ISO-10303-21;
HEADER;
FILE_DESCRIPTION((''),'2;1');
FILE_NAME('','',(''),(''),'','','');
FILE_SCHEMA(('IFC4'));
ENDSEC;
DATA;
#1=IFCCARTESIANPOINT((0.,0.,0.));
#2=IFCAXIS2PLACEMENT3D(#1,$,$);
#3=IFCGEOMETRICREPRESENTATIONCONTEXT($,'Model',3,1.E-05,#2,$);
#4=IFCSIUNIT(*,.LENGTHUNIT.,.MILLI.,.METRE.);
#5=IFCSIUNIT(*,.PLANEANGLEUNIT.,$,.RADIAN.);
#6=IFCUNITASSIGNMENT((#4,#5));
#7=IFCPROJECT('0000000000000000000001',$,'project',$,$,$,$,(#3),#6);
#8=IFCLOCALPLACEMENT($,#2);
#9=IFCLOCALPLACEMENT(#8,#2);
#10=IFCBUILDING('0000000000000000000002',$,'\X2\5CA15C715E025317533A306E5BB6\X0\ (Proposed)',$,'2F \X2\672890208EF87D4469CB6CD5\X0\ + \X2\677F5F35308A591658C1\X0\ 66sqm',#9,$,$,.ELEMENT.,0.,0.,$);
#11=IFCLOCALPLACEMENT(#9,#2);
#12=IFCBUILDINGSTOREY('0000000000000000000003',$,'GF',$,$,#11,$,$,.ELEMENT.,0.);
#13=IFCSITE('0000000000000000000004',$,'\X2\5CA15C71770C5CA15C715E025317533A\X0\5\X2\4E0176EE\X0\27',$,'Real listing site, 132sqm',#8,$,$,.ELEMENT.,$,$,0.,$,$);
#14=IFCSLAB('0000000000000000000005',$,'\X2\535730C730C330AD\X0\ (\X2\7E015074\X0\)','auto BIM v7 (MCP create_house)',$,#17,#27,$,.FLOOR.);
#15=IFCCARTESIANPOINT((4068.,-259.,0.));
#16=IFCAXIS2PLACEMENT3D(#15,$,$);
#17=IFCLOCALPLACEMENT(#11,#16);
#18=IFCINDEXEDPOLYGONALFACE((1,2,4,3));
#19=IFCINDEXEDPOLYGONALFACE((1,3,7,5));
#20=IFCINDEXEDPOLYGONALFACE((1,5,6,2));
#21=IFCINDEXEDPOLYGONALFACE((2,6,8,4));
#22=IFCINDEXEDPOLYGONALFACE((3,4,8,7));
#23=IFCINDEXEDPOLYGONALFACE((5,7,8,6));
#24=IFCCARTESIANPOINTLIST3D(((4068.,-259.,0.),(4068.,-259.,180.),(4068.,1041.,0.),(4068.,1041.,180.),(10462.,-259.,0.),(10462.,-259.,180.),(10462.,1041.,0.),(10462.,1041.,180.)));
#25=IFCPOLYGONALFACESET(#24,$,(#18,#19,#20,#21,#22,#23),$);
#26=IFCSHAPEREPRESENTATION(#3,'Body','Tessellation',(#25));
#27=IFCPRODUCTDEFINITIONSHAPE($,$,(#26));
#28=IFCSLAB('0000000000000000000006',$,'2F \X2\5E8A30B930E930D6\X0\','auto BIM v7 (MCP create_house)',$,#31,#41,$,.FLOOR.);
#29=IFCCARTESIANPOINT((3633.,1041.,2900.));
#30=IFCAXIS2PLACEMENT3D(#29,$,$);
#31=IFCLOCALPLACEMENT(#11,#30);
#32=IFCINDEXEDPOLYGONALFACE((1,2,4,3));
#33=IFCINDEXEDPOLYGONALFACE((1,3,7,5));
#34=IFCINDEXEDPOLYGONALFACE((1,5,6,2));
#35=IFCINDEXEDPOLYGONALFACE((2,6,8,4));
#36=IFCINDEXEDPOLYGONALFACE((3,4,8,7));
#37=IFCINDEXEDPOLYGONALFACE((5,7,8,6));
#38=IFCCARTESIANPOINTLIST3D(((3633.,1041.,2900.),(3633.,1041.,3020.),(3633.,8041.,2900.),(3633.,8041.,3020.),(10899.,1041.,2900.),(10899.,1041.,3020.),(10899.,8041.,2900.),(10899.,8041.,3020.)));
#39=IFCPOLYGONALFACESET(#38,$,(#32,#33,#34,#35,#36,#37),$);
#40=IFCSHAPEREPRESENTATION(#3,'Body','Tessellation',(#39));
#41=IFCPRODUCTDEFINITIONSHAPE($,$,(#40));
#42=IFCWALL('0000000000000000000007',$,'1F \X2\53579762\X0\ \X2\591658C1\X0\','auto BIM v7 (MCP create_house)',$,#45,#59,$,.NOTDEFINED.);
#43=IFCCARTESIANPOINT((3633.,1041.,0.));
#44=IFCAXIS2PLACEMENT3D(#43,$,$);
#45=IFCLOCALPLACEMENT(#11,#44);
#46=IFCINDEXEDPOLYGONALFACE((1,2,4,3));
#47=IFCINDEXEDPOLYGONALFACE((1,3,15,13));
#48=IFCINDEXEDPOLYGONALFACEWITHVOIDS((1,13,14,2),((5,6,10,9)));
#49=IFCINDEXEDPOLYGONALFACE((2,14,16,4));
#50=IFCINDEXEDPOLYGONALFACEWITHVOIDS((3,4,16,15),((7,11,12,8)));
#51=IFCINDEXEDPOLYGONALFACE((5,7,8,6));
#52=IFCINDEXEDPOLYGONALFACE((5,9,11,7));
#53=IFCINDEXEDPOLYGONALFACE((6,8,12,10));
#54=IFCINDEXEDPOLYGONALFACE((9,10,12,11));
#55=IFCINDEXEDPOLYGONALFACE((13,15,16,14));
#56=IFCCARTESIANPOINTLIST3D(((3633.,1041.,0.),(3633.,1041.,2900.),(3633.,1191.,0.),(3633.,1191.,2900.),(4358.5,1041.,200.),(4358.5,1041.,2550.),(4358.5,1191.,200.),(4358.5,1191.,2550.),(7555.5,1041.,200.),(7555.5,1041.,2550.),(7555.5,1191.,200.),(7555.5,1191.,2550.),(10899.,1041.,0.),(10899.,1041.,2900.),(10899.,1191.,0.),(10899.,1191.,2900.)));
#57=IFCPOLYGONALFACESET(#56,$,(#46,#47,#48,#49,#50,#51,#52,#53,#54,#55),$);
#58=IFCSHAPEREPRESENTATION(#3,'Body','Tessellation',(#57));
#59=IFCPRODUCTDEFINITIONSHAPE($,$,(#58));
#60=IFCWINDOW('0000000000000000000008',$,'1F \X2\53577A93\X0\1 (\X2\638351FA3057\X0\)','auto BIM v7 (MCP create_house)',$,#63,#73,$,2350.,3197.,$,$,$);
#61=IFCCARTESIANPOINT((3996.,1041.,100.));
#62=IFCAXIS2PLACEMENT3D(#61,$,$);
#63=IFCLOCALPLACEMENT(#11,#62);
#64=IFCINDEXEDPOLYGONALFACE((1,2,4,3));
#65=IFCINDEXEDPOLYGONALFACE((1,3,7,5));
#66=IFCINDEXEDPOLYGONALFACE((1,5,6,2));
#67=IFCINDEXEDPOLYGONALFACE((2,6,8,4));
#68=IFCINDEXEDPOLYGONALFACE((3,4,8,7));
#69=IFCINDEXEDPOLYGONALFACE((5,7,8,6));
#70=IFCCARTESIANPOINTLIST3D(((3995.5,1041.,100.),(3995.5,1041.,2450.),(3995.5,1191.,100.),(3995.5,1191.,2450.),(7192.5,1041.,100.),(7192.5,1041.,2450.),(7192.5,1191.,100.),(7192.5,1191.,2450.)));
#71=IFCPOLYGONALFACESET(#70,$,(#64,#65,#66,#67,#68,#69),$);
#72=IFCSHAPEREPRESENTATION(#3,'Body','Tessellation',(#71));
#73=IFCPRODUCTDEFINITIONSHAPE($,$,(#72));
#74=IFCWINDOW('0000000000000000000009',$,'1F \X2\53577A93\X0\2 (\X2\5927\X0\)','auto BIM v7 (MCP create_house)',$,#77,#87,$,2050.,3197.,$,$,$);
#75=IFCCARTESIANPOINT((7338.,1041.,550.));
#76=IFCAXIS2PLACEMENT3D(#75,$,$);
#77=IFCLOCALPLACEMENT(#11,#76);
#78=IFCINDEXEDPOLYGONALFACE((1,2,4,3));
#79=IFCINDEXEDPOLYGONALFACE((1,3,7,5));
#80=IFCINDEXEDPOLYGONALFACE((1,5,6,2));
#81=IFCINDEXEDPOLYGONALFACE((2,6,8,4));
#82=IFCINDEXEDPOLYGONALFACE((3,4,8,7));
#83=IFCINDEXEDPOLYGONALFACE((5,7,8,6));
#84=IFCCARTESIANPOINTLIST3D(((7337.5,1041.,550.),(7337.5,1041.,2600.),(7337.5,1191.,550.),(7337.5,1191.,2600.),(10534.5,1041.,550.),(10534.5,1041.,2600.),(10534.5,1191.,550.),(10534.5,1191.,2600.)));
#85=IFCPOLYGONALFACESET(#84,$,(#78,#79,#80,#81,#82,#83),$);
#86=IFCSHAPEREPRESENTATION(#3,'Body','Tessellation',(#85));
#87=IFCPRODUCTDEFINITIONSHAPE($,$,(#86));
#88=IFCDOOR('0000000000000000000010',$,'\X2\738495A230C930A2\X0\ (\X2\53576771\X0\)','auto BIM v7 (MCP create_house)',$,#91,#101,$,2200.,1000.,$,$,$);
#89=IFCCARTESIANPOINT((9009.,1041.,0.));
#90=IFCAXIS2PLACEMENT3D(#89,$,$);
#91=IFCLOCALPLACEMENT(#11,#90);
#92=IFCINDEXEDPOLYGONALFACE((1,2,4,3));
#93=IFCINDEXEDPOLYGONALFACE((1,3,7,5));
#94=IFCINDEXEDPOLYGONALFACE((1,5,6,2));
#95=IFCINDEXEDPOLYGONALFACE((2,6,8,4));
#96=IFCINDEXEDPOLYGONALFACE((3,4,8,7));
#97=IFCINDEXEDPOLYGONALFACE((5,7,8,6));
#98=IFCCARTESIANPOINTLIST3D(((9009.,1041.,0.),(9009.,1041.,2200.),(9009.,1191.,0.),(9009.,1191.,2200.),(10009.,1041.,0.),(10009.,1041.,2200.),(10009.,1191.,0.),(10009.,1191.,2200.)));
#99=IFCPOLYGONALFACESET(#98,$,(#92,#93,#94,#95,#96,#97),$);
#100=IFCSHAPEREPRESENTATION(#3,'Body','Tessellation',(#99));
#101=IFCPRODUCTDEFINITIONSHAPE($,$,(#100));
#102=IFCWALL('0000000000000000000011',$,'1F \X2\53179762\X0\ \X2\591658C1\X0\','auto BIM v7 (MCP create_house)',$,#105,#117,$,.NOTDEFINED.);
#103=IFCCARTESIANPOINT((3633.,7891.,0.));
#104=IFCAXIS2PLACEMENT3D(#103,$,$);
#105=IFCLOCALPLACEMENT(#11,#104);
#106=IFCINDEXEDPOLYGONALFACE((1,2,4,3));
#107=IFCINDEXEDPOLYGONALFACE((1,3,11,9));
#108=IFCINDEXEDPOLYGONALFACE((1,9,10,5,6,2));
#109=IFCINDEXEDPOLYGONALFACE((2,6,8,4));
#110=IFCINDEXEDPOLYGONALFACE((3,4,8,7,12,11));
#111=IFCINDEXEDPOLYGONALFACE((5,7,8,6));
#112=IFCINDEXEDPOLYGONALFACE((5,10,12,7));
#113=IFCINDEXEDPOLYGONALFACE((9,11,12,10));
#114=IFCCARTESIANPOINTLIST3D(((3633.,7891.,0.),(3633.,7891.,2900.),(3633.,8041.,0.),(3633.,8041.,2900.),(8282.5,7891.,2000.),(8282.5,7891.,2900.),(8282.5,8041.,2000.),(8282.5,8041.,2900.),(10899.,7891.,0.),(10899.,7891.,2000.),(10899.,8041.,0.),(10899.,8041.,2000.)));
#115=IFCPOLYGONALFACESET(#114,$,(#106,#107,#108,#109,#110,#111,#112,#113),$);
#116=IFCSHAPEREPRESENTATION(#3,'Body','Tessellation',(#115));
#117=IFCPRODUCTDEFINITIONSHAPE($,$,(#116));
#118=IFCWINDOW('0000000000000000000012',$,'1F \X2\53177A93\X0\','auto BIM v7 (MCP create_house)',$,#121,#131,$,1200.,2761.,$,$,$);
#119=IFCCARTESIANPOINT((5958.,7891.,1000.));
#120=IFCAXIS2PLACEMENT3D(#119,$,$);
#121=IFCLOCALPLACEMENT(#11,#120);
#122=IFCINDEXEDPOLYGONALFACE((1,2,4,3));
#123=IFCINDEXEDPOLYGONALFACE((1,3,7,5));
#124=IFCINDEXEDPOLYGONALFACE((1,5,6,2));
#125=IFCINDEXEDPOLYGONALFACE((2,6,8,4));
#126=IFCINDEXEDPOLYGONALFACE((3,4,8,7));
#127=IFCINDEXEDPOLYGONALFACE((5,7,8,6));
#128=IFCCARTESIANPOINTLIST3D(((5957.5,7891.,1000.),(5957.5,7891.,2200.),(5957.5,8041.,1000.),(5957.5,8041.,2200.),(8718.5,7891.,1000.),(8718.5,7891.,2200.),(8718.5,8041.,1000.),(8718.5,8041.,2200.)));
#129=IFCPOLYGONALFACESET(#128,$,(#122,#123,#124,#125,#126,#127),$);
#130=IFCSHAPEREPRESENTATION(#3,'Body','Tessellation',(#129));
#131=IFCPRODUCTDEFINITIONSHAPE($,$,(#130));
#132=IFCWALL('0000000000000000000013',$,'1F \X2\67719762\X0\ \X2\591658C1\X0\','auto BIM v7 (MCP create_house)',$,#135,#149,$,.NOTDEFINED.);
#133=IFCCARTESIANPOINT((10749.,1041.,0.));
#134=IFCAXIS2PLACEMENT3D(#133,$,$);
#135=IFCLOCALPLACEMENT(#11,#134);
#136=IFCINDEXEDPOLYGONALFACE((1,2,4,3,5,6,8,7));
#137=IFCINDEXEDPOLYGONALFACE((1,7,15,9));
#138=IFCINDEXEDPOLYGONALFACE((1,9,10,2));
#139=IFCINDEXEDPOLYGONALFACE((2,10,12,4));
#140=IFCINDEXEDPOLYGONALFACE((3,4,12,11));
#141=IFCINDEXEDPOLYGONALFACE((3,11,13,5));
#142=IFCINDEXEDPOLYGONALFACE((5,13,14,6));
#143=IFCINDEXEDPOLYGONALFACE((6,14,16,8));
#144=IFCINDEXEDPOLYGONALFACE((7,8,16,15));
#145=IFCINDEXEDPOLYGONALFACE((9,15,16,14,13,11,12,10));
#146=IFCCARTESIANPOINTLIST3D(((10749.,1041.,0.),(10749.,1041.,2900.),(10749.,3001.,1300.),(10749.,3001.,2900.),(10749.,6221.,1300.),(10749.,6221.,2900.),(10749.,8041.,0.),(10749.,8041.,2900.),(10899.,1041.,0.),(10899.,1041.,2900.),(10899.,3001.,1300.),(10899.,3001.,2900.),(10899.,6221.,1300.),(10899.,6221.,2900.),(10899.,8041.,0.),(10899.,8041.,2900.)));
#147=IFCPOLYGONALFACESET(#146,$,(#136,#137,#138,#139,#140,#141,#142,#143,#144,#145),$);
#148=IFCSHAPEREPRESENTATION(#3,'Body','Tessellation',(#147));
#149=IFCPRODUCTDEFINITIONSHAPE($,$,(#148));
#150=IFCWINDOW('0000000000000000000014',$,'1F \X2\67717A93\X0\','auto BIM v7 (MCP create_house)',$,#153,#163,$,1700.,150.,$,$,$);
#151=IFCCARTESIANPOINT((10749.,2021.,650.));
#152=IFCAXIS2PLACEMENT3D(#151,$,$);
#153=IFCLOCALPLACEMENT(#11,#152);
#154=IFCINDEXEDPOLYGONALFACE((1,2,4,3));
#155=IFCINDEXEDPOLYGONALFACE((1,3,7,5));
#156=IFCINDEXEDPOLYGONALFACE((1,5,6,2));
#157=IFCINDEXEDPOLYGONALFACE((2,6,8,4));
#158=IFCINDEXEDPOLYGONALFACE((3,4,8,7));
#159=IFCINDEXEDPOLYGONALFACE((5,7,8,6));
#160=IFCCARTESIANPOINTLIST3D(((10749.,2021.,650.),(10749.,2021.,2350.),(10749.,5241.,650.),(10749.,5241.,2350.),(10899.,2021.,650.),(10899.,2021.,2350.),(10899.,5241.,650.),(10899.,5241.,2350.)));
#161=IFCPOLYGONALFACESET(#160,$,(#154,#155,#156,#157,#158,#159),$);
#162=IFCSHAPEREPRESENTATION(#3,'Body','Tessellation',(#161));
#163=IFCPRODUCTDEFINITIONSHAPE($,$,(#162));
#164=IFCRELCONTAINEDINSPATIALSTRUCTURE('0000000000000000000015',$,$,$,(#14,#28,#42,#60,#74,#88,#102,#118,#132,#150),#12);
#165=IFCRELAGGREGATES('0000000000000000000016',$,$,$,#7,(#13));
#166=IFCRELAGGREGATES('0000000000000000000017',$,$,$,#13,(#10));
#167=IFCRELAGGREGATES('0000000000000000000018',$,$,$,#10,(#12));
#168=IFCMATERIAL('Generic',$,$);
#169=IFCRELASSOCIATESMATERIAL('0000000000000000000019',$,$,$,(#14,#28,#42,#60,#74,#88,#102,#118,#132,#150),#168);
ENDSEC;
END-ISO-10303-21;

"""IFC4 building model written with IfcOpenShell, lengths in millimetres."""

from ifc_helpers import new_model, si_unit, frame, frame_2d, origin, place, context, project, spatial, rectangle, extrude, material, element, fill, save


model = new_model("IFC4")

# Units and contexts
model_context = context("Model", 3, precision=1e-05, world=origin())
ifc_project = project(units=[si_unit("LENGTHUNIT", "METRE", prefix="MILLI"), si_unit("PLANEANGLEUNIT", "RADIAN")], contexts=[model_context])

# Site, building, storey
site_placement = place(None, origin())
site = spatial("IfcSite", under=ifc_project, at=site_placement, Name="岡山県岡山市北区5丁目27", ObjectType="Real listing site, 132sqm", CompositionType="ELEMENT", RefElevation=0.0)
building_placement = place(site_placement, origin())
building = spatial("IfcBuilding", under=site, at=building_placement, Name="岡山市北区の家 (Proposed)", ObjectType="2F 木造軸組構法 + 板張り外壁 66sqm", CompositionType="ELEMENT", ElevationOfRefHeight=0.0, ElevationOfTerrain=0.0)
storey_placement = place(building_placement, origin())
storey = spatial("IfcBuildingStorey", under=building, at=storey_placement, Name="GF", CompositionType="ELEMENT", Elevation=0.0)

# Slabs
ifc_material = material(Name="Generic")
slab_1_placement = place(storey_placement, frame((4068.0, -259.0, 0.0)))
element("IfcSlab", 1, at=slab_1_placement, inside=storey, material=ifc_material, Name="南デッキ (縁側)", Description="auto BIM v7 (MCP create_house)", PredefinedType="FLOOR", context=model_context, shape_type="SweptSolid", body=[
    extrude(rectangle(XDim=6394.0, YDim=1300.0, at=frame_2d((3197.0, 650.0))), frame((4068.0, -259.0, 0.0)), (0.0, 0.0, 1.0), 180.0),
])
slab_2_placement = place(storey_placement, frame((3633.0, 1041.0, 2900.0)))
element("IfcSlab", 2, at=slab_2_placement, inside=storey, material=ifc_material, Name="2F 床スラブ", Description="auto BIM v7 (MCP create_house)", PredefinedType="FLOOR", context=model_context, shape_type="SweptSolid", body=[
    extrude(rectangle(XDim=7266.0, YDim=7000.0, at=frame_2d((3633.0, 3500.0))), frame((3633.0, 1041.0, 2900.0)), (0.0, 0.0, 1.0), 120.0),
])

# Wall, openings, windows, door
wall_1_placement = place(storey_placement, frame((3633.0, 1041.0, 0.0)))
wall_1 = element("IfcWall", 3, at=wall_1_placement, inside=storey, material=ifc_material, Name="1F 南面 外壁", Description="auto BIM v7 (MCP create_house)", PredefinedType="NOTDEFINED", context=model_context, shape_type="SweptSolid", body=[
    extrude(rectangle(XDim=7266.0, YDim=150.0, at=frame_2d((3633.0, 75.0))), frame((3633.0, 1041.0, 0.0)), (0.0, 0.0, 1.0), 2900.0),
])
opening_1_placement = place(storey_placement, frame((3996.0, 1041.0, 100.0)))
opening_1 = element("IfcOpeningElement", 4, at=opening_1_placement, cuts=wall_1, PredefinedType="NOTDEFINED", context=model_context, shape_type="SweptSolid", body=[
    extrude(rectangle(XDim=3197.0, YDim=150.0, at=frame_2d((1598.0, 75.0))), frame((3996.0, 1041.0, 100.0)), (0.0, 0.0, 1.0), 2350.0),
])
opening_2_placement = place(storey_placement, frame((7338.0, 1041.0, 550.0)))
opening_2 = element("IfcOpeningElement", 5, at=opening_2_placement, cuts=wall_1, PredefinedType="NOTDEFINED", context=model_context, shape_type="SweptSolid", body=[
    extrude(rectangle(XDim=3197.0, YDim=150.0, at=frame_2d((1598.0, 75.0))), frame((7338.0, 1041.0, 550.0)), (0.0, 0.0, 1.0), 2050.0),
])
opening_3_placement = place(storey_placement, frame((9009.0, 1041.0, 0.0)))
opening_3 = element("IfcOpeningElement", 6, at=opening_3_placement, cuts=wall_1, PredefinedType="NOTDEFINED", context=model_context, shape_type="SweptSolid", body=[
    extrude(rectangle(XDim=1000.0, YDim=150.0, at=frame_2d((500.0, 75.0))), frame((9009.0, 1041.0, 0.0)), (0.0, 0.0, 1.0), 2200.0),
])
window_1_placement = place(storey_placement, frame((3996.0, 1041.0, 100.0)))
window_1 = element("IfcWindow", 7, at=window_1_placement, inside=storey, material=ifc_material, Name="1F 南窓1 (掃出し)", Description="auto BIM v7 (MCP create_house)", OverallHeight=2350.0, OverallWidth=3197.0, context=model_context, shape_type="SweptSolid", body=[
    extrude(rectangle(XDim=3197.0, YDim=150.0, at=frame_2d((1598.0, 75.0))), frame((3996.0, 1041.0, 100.0)), (0.0, 0.0, 1.0), 2350.0),
])
fill(opening_1, window_1)
window_2_placement = place(storey_placement, frame((7338.0, 1041.0, 550.0)))
window_2 = element("IfcWindow", 8, at=window_2_placement, inside=storey, material=ifc_material, Name="1F 南窓2 (大)", Description="auto BIM v7 (MCP create_house)", OverallHeight=2050.0, OverallWidth=3197.0, context=model_context, shape_type="SweptSolid", body=[
    extrude(rectangle(XDim=3197.0, YDim=150.0, at=frame_2d((1598.0, 75.0))), frame((7338.0, 1041.0, 550.0)), (0.0, 0.0, 1.0), 2050.0),
])
fill(opening_2, window_2)
door_placement = place(storey_placement, frame((9009.0, 1041.0, 0.0)))
door = element("IfcDoor", 9, at=door_placement, inside=storey, material=ifc_material, Name="玄関ドア (南東)", Description="auto BIM v7 (MCP create_house)", OverallHeight=2200.0, OverallWidth=1000.0, context=model_context, shape_type="SweptSolid", body=[
    extrude(rectangle(XDim=1000.0, YDim=150.0, at=frame_2d((500.0, 75.0))), frame((9009.0, 1041.0, 0.0)), (0.0, 0.0, 1.0), 2200.0),
])
fill(opening_3, door)

# Walls, openings, windows
wall_2_placement = place(storey_placement, frame((3633.0, 7891.0, 0.0)))
wall_2 = element("IfcWall", 10, at=wall_2_placement, inside=storey, material=ifc_material, Name="1F 北面 外壁", Description="auto BIM v7 (MCP create_house)", PredefinedType="NOTDEFINED", context=model_context, shape_type="SweptSolid", body=[
    extrude(rectangle(XDim=7266.0, YDim=150.0, at=frame_2d((3633.0, 75.0))), frame((3633.0, 7891.0, 0.0)), (0.0, 0.0, 1.0), 2900.0),
])
opening_4_placement = place(storey_placement, frame((5958.0, 7891.0, 1000.0)))
opening_4 = element("IfcOpeningElement", 11, at=opening_4_placement, cuts=wall_2, PredefinedType="NOTDEFINED", context=model_context, shape_type="SweptSolid", body=[
    extrude(rectangle(XDim=2761.0, YDim=150.0, at=frame_2d((1380.0, 75.0))), frame((5958.0, 7891.0, 1000.0)), (0.0, 0.0, 1.0), 1200.0),
])
window_3_placement = place(storey_placement, frame((5958.0, 7891.0, 1000.0)))
window_3 = element("IfcWindow", 12, at=window_3_placement, inside=storey, material=ifc_material, Name="1F 北窓", Description="auto BIM v7 (MCP create_house)", OverallHeight=1200.0, OverallWidth=2761.0, context=model_context, shape_type="SweptSolid", body=[
    extrude(rectangle(XDim=2761.0, YDim=150.0, at=frame_2d((1380.0, 75.0))), frame((5958.0, 7891.0, 1000.0)), (0.0, 0.0, 1.0), 1200.0),
])
fill(opening_4, window_3)
wall_3_placement = place(storey_placement, frame((10749.0, 1041.0, 0.0)))
wall_3 = element("IfcWall", 13, at=wall_3_placement, inside=storey, material=ifc_material, Name="1F 東面 外壁", Description="auto BIM v7 (MCP create_house)", PredefinedType="NOTDEFINED", context=model_context, shape_type="SweptSolid", body=[
    extrude(rectangle(XDim=150.0, YDim=7000.0, at=frame_2d((75.0, 3500.0))), frame((10749.0, 1041.0, 0.0)), (0.0, 0.0, 1.0), 2900.0),
])
opening_5_placement = place(storey_placement, frame((10749.0, 2021.0, 650.0)))
opening_5 = element("IfcOpeningElement", 14, at=opening_5_placement, cuts=wall_3, PredefinedType="NOTDEFINED", context=model_context, shape_type="SweptSolid", body=[
    extrude(rectangle(XDim=150.0, YDim=3220.0, at=frame_2d((75.0, 1610.0))), frame((10749.0, 2021.0, 650.0)), (0.0, 0.0, 1.0), 1700.0),
])
window_4_placement = place(storey_placement, frame((10749.0, 2021.0, 650.0)))
window_4 = element("IfcWindow", 15, at=window_4_placement, inside=storey, material=ifc_material, Name="1F 東窓", Description="auto BIM v7 (MCP create_house)", OverallHeight=1700.0, OverallWidth=150.0, context=model_context, shape_type="SweptSolid", body=[
    extrude(rectangle(XDim=150.0, YDim=3220.0, at=frame_2d((75.0, 1610.0))), frame((10749.0, 2021.0, 650.0)), (0.0, 0.0, 1.0), 1700.0),
])
fill(opening_5, window_4)

save(model, "model.ifc")
